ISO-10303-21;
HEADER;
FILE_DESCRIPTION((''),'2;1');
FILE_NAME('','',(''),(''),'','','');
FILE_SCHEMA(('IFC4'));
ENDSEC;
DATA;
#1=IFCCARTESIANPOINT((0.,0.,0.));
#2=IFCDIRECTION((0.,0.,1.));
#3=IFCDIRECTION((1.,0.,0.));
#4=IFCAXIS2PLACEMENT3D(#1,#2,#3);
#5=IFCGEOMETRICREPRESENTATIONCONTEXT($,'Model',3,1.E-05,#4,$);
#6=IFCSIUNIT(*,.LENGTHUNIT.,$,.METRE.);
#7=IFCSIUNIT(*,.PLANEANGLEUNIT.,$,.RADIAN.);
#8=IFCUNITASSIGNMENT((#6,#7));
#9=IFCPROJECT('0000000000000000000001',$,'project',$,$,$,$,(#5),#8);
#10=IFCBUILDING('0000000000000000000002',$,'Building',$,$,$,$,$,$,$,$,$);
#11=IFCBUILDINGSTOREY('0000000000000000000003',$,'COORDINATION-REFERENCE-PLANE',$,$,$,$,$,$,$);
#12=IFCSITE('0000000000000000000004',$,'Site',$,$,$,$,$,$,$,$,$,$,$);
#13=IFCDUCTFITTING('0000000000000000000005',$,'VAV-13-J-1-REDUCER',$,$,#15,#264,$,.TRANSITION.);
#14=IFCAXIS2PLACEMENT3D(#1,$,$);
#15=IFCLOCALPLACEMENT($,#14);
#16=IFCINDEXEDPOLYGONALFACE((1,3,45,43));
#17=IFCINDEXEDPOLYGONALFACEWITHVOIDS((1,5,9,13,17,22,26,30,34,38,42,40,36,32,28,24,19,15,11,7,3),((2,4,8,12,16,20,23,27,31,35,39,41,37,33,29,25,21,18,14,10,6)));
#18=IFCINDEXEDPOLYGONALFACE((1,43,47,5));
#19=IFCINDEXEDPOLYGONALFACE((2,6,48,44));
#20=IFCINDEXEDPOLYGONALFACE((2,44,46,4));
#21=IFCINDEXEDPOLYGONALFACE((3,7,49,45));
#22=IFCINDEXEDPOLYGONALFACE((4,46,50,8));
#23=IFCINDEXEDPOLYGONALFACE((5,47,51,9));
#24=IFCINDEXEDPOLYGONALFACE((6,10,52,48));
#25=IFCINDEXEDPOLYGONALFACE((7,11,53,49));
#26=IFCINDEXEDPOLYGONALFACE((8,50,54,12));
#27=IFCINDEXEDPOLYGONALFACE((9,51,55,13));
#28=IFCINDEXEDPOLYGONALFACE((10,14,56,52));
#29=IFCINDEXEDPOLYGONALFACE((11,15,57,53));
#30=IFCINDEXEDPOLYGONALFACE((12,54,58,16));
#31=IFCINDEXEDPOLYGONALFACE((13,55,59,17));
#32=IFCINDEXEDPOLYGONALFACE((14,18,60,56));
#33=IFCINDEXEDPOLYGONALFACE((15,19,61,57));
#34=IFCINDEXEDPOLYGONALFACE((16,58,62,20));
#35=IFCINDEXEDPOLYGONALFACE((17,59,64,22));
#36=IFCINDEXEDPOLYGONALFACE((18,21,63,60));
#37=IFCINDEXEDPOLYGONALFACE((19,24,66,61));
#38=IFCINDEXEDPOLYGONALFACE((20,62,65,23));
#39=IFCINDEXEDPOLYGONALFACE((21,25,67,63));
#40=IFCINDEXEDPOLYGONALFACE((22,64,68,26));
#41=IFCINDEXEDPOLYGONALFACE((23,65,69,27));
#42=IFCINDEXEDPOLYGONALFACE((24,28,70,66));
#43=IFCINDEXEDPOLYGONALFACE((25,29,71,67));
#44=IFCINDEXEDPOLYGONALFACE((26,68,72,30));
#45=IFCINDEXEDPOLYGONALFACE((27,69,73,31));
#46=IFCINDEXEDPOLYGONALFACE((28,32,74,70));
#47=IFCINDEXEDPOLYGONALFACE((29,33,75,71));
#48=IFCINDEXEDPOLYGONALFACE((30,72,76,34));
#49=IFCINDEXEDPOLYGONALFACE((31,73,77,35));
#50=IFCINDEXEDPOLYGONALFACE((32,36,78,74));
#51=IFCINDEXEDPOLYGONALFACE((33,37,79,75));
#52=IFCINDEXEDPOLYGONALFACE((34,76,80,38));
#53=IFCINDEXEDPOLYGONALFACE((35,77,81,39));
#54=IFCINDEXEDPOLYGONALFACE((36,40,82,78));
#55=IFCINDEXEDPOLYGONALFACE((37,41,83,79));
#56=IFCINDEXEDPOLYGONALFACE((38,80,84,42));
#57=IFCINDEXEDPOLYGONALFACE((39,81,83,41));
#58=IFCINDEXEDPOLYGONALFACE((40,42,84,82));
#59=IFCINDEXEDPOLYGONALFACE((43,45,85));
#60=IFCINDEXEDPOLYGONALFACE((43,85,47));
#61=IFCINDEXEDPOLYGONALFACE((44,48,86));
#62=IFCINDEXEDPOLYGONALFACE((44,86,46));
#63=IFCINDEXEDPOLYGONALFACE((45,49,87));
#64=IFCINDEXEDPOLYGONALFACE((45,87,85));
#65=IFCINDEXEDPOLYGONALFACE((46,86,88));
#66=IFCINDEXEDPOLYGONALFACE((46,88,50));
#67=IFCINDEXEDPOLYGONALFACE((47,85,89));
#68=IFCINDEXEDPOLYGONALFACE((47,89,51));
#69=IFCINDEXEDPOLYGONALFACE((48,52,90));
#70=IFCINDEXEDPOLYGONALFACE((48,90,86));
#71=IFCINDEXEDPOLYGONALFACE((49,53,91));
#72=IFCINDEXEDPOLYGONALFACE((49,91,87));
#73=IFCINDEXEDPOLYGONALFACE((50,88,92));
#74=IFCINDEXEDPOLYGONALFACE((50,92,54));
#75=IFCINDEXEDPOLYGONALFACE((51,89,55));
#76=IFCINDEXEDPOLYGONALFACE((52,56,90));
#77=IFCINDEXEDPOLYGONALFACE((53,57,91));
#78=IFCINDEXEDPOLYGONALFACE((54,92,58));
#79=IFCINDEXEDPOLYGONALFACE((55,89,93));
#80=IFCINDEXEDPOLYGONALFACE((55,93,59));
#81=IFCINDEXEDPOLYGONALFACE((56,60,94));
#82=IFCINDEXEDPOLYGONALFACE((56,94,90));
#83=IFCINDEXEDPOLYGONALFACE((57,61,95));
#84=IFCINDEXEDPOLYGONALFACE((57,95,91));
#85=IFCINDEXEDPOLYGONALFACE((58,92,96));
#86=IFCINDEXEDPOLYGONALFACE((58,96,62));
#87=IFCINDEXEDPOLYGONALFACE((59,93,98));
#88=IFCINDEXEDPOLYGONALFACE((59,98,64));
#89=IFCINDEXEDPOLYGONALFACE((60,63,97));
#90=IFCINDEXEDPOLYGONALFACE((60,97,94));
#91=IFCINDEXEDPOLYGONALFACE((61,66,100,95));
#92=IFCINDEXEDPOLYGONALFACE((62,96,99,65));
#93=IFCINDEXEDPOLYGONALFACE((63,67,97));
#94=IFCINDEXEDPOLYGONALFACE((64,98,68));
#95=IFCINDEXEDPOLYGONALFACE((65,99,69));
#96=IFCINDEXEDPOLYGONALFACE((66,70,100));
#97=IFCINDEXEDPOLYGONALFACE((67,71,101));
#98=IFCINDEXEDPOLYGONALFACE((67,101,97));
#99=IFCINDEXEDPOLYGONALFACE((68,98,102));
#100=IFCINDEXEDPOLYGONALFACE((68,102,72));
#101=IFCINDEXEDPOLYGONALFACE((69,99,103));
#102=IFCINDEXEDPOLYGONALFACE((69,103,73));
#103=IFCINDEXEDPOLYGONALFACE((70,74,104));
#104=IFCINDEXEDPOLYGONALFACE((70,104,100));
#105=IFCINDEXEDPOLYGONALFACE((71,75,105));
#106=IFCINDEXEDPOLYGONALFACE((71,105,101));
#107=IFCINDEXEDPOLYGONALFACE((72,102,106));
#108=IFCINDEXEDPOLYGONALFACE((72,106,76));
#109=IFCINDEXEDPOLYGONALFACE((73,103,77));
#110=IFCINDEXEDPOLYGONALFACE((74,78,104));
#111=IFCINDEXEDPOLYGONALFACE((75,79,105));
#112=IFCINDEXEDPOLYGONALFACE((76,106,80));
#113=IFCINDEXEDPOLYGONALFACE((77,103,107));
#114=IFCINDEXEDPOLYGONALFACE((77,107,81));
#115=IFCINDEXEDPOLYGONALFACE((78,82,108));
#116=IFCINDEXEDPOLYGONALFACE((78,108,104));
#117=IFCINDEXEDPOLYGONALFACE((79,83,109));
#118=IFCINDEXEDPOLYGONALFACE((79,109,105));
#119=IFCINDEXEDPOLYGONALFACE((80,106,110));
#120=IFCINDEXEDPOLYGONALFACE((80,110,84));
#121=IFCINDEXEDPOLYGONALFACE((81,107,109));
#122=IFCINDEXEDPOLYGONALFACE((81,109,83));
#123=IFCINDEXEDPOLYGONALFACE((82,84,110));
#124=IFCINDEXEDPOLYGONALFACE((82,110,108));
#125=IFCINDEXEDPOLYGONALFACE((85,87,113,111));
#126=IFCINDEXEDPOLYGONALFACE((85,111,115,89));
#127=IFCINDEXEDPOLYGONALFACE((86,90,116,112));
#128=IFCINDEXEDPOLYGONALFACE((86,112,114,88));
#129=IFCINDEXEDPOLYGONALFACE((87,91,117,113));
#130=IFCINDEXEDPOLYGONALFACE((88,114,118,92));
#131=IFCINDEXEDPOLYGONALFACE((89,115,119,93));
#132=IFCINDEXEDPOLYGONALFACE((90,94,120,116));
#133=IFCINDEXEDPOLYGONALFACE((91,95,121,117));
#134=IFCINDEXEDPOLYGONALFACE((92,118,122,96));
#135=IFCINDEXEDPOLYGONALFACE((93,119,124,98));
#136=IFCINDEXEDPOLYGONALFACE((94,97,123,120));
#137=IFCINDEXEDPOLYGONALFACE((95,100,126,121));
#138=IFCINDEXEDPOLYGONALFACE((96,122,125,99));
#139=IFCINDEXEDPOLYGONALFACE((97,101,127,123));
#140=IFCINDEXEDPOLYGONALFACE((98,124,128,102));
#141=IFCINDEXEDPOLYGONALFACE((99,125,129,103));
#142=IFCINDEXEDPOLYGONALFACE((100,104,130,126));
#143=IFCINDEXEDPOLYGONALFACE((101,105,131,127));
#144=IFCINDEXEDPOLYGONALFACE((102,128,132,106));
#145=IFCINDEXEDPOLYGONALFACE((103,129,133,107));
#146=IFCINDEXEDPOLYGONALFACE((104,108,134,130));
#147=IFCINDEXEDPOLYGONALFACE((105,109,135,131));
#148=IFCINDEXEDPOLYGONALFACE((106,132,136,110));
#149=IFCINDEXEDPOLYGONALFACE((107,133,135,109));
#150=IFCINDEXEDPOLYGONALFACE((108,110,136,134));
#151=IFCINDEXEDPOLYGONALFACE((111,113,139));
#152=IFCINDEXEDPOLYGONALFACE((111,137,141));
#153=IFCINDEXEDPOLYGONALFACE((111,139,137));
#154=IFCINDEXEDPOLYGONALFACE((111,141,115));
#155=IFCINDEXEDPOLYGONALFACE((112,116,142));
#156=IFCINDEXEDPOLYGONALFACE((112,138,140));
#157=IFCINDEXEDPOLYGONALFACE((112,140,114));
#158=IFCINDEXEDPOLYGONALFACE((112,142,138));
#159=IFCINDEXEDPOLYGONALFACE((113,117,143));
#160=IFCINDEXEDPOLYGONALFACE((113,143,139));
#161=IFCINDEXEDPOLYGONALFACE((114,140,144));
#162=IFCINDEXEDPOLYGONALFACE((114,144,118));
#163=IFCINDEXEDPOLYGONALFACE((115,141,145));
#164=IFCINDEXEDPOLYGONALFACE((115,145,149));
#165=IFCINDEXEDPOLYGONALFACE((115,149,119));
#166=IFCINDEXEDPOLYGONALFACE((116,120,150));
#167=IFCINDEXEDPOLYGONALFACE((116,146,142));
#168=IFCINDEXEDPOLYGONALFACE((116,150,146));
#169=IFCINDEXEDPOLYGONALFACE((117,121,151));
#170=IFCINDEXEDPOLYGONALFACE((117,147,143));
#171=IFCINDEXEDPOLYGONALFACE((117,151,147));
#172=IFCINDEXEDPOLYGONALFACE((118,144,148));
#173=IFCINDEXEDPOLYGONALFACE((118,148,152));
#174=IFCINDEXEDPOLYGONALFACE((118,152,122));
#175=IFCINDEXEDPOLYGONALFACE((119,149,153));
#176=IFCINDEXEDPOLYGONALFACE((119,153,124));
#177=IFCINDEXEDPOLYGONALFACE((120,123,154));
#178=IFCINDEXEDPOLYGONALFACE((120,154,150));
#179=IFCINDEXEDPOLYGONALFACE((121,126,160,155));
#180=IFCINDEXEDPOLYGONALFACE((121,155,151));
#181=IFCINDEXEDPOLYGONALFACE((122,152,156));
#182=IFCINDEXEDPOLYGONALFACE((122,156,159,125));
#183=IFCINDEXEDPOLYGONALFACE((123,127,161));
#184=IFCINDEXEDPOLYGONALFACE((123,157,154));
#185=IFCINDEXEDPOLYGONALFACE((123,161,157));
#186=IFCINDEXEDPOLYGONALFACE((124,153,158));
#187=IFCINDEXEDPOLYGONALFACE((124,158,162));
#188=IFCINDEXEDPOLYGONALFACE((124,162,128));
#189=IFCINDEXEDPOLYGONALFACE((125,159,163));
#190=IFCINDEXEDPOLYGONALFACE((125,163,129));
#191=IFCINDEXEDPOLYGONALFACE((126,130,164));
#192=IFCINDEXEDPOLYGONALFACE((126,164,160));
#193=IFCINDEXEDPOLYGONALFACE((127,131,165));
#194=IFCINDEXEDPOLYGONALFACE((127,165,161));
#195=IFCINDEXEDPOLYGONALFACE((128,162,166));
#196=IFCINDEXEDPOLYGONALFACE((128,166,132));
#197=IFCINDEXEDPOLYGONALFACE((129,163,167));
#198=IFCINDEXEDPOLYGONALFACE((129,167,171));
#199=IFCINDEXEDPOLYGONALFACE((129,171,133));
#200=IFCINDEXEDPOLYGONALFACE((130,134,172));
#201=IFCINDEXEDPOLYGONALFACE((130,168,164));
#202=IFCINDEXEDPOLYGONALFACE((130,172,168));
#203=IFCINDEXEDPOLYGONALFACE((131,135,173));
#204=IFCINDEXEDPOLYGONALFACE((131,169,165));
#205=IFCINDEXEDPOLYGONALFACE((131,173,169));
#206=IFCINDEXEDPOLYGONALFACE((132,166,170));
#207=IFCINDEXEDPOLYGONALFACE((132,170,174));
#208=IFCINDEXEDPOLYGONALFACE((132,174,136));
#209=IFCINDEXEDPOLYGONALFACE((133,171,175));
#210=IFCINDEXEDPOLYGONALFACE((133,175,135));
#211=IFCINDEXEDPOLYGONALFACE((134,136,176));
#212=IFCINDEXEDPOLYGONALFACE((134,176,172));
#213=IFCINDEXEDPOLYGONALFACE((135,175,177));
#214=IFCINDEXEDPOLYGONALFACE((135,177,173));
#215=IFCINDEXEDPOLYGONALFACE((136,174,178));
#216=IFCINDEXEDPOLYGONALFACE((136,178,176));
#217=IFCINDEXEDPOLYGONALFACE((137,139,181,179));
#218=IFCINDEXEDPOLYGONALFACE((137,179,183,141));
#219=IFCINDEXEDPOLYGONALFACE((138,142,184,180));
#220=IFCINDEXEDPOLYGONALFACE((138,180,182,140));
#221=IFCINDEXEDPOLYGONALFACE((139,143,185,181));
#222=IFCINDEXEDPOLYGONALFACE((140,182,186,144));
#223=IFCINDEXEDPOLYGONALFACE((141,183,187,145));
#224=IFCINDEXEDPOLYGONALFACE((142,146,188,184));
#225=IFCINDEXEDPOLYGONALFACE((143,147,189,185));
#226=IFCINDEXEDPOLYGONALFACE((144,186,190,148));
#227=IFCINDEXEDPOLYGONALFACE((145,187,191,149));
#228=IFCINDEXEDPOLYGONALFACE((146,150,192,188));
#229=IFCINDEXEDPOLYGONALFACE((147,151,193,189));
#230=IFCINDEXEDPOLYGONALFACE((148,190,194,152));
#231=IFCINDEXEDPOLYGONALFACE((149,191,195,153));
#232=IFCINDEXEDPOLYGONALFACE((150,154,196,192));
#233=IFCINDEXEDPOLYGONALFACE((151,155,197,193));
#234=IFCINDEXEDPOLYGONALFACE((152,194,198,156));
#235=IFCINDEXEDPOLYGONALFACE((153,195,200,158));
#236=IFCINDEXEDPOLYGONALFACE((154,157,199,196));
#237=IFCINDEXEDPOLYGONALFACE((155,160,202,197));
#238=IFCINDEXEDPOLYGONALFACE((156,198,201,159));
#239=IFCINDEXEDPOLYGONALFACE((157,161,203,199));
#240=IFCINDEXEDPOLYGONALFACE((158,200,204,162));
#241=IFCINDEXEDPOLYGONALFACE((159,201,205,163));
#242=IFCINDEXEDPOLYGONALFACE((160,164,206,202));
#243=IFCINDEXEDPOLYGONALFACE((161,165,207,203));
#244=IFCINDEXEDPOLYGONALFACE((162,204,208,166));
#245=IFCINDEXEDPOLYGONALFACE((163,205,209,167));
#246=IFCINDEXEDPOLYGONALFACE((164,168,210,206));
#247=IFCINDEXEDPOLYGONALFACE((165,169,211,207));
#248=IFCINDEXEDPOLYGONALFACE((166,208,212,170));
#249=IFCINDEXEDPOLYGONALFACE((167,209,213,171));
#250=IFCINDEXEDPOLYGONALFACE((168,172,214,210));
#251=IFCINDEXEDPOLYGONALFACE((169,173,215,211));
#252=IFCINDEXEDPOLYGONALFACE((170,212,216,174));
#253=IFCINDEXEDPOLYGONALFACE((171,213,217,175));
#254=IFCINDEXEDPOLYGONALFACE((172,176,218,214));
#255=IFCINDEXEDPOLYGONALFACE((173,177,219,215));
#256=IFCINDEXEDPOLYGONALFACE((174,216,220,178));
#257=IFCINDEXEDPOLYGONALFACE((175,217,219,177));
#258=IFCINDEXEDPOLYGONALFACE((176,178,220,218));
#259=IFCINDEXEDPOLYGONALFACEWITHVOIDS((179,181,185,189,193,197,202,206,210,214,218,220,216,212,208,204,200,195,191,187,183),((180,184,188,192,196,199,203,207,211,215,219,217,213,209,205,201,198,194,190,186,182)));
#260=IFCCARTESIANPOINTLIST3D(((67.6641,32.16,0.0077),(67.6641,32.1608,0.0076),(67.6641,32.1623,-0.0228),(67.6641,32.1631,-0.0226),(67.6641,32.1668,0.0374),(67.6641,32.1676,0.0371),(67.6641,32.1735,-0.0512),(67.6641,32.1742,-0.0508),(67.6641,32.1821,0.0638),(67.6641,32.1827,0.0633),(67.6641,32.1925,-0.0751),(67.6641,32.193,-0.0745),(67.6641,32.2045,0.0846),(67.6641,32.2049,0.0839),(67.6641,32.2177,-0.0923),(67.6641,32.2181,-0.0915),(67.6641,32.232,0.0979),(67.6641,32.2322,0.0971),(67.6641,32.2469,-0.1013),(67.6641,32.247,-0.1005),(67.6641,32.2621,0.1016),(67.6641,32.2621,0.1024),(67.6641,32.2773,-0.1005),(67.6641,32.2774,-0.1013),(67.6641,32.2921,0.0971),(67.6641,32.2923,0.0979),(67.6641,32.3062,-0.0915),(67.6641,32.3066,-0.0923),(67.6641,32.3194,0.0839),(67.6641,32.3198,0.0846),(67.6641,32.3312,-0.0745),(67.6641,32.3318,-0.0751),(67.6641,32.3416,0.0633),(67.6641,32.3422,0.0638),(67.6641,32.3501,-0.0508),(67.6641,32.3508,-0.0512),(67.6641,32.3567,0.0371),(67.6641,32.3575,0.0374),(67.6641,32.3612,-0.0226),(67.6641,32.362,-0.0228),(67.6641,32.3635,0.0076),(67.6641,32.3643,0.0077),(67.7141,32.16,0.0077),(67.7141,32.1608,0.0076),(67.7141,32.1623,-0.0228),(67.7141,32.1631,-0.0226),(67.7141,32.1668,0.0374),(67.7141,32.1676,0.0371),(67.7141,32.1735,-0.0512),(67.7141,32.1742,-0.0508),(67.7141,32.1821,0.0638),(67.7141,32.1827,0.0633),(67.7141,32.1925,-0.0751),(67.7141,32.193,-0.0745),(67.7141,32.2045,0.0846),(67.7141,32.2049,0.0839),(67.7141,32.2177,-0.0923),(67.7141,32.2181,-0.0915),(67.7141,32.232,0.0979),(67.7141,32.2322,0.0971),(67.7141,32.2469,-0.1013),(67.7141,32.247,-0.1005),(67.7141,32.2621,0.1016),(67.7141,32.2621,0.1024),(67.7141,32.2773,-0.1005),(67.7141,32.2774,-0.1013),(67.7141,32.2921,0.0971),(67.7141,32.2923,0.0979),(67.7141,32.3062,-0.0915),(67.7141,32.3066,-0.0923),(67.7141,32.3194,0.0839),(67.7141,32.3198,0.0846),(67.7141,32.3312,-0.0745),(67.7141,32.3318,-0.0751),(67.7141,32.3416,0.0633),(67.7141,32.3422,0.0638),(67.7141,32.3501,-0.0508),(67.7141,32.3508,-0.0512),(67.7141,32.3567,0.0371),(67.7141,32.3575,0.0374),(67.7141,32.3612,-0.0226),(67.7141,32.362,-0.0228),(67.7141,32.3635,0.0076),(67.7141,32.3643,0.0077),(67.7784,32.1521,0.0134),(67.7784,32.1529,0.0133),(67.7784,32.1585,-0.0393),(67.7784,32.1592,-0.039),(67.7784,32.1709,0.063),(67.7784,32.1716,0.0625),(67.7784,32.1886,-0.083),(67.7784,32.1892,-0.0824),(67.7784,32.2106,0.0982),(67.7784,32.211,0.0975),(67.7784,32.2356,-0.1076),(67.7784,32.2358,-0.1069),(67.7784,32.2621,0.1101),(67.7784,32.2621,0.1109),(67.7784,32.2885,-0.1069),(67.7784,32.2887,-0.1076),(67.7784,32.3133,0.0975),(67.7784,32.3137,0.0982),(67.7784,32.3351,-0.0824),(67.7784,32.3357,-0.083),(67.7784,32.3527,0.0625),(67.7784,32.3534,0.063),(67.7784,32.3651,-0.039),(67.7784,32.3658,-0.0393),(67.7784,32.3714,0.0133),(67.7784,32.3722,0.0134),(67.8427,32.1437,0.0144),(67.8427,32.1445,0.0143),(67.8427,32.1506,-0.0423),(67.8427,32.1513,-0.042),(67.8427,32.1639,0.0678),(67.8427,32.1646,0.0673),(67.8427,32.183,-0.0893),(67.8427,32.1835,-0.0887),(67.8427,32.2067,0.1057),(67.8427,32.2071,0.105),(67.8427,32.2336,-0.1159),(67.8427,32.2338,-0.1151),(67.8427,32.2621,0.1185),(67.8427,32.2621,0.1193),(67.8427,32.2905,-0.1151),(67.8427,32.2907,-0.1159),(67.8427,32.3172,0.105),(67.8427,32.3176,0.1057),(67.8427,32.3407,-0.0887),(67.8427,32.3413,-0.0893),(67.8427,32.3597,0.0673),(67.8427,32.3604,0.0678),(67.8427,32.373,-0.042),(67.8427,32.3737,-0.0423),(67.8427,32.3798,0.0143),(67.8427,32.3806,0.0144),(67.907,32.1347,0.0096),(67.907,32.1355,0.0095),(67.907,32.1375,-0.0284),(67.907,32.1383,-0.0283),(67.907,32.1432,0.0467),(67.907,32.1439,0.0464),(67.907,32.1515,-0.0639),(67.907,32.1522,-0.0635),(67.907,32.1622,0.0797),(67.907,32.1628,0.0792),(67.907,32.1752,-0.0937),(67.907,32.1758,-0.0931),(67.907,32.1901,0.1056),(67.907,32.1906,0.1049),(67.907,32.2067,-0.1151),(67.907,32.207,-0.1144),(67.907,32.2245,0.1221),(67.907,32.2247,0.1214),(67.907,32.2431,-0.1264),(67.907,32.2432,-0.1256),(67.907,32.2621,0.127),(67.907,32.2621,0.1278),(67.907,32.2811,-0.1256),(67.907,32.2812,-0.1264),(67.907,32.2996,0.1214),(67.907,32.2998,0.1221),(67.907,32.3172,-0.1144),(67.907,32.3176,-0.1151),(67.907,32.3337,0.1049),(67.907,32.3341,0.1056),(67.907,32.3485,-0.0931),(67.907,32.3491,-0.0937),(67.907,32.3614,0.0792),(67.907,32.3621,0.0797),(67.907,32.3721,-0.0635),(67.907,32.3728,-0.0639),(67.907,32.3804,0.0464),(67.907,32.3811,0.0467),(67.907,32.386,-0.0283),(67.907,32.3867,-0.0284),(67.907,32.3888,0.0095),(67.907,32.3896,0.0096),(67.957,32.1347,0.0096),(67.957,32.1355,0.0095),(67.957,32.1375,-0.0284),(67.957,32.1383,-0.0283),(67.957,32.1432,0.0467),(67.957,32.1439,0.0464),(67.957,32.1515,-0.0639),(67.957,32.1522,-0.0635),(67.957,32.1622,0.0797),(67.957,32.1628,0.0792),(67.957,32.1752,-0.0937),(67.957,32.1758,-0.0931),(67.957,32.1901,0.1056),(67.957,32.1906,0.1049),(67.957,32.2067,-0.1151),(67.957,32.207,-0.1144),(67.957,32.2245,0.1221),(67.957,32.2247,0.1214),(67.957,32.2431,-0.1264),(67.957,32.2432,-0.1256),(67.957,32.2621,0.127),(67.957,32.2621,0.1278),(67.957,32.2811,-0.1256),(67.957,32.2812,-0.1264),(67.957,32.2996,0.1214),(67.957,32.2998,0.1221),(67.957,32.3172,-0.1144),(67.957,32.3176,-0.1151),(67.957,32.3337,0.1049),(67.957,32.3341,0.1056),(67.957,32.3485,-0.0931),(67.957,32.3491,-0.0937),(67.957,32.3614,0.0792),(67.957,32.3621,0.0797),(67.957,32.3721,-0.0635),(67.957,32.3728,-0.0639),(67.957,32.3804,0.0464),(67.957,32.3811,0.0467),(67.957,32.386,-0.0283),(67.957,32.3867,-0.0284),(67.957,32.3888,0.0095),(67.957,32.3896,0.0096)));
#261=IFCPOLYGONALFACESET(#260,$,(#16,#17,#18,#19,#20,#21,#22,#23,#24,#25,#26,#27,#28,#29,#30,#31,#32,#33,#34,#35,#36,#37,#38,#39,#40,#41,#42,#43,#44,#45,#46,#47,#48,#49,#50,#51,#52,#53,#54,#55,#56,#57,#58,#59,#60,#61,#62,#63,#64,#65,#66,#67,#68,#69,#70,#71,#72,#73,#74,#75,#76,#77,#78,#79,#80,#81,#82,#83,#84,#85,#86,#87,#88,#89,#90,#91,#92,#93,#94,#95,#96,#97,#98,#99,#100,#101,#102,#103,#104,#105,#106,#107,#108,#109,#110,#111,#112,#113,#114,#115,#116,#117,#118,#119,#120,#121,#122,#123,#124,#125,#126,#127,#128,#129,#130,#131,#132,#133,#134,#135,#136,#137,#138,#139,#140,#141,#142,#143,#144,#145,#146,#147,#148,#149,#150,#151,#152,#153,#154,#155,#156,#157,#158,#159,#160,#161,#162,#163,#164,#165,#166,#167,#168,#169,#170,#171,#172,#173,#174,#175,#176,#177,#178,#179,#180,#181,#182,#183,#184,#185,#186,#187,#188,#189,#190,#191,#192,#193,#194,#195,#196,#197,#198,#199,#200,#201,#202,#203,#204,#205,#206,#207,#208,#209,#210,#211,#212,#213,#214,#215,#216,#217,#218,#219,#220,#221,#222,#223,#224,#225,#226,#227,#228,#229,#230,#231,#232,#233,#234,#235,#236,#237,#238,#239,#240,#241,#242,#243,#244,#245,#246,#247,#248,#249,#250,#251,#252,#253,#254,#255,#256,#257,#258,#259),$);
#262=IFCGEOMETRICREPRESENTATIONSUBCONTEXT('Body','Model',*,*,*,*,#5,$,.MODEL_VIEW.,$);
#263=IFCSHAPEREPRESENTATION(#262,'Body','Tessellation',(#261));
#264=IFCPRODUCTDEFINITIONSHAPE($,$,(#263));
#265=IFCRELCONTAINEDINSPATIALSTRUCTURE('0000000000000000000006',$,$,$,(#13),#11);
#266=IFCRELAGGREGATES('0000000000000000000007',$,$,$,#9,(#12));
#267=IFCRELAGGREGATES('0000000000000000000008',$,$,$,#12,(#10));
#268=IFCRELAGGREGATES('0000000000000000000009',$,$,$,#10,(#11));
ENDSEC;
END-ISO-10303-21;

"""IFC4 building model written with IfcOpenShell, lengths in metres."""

from ifc_helpers import new_model, entity, si_unit, frame, origin_with_axes, place, context, subcontext, project, spatial, element, save


model = new_model("IFC4")

# Units and contexts
model_context = context("Model", 3, precision=1e-05, world=origin_with_axes())
body_context_1 = subcontext(model_context, "Body", "Model", "MODEL_VIEW")
ifc_project = project(units=[si_unit("LENGTHUNIT", "METRE"), si_unit("PLANEANGLEUNIT", "RADIAN")], contexts=[model_context])

# Site, building, storey
site = spatial("IfcSite", under=ifc_project, Name="Site")
building = spatial("IfcBuilding", under=site, Name="Building")
storey = spatial("IfcBuildingStorey", under=building, Name="COORDINATION-REFERENCE-PLANE")

# Duct fitting
for number, where, z_axis, x_axis, name in (
    (1, (67.957, 32.2621, 0.0), (0.0, -1.0, 0.0), (0.0, 0.0, 1.0), "VAV-13-J-1-REDUCER"),
):
    element("IfcDuctFitting", number, at=place(None, frame(where, z_axis=z_axis, x_axis=x_axis)), inside=storey, Name=name, PredefinedType="TRANSITION", context=body_context_1, shape_type="SweptSolid", body=[
        entity("IfcRevolvedAreaSolid", entity("IfcArbitraryClosedProfileDef", "AREA", None, entity("IfcPolyline", [entity("IfcCartesianPoint", [0.1278, 0.0]), entity("IfcCartesianPoint", [0.1278, 0.05]), entity("IfcCartesianPoint", [0.1024, 0.2429]), entity("IfcCartesianPoint", [0.1024, 0.2929]), entity("IfcCartesianPoint", [0.1016, 0.2929]), entity("IfcCartesianPoint", [0.1016, 0.2429]), entity("IfcCartesianPoint", [0.127, 0.05]), entity("IfcCartesianPoint", [0.127, 0.0]), entity("IfcCartesianPoint", [0.1278, 0.0])])), entity("IfcAxis2Placement3D", entity("IfcCartesianPoint", [0.0, 0.0, 0.0])), entity("IfcAxis1Placement", entity("IfcCartesianPoint", [0.0, 0.0, 0.0]), entity("IfcDirection", [0.0, 1.0, 0.0])), 6.283185),
    ])

save(model, "model.ifc")
